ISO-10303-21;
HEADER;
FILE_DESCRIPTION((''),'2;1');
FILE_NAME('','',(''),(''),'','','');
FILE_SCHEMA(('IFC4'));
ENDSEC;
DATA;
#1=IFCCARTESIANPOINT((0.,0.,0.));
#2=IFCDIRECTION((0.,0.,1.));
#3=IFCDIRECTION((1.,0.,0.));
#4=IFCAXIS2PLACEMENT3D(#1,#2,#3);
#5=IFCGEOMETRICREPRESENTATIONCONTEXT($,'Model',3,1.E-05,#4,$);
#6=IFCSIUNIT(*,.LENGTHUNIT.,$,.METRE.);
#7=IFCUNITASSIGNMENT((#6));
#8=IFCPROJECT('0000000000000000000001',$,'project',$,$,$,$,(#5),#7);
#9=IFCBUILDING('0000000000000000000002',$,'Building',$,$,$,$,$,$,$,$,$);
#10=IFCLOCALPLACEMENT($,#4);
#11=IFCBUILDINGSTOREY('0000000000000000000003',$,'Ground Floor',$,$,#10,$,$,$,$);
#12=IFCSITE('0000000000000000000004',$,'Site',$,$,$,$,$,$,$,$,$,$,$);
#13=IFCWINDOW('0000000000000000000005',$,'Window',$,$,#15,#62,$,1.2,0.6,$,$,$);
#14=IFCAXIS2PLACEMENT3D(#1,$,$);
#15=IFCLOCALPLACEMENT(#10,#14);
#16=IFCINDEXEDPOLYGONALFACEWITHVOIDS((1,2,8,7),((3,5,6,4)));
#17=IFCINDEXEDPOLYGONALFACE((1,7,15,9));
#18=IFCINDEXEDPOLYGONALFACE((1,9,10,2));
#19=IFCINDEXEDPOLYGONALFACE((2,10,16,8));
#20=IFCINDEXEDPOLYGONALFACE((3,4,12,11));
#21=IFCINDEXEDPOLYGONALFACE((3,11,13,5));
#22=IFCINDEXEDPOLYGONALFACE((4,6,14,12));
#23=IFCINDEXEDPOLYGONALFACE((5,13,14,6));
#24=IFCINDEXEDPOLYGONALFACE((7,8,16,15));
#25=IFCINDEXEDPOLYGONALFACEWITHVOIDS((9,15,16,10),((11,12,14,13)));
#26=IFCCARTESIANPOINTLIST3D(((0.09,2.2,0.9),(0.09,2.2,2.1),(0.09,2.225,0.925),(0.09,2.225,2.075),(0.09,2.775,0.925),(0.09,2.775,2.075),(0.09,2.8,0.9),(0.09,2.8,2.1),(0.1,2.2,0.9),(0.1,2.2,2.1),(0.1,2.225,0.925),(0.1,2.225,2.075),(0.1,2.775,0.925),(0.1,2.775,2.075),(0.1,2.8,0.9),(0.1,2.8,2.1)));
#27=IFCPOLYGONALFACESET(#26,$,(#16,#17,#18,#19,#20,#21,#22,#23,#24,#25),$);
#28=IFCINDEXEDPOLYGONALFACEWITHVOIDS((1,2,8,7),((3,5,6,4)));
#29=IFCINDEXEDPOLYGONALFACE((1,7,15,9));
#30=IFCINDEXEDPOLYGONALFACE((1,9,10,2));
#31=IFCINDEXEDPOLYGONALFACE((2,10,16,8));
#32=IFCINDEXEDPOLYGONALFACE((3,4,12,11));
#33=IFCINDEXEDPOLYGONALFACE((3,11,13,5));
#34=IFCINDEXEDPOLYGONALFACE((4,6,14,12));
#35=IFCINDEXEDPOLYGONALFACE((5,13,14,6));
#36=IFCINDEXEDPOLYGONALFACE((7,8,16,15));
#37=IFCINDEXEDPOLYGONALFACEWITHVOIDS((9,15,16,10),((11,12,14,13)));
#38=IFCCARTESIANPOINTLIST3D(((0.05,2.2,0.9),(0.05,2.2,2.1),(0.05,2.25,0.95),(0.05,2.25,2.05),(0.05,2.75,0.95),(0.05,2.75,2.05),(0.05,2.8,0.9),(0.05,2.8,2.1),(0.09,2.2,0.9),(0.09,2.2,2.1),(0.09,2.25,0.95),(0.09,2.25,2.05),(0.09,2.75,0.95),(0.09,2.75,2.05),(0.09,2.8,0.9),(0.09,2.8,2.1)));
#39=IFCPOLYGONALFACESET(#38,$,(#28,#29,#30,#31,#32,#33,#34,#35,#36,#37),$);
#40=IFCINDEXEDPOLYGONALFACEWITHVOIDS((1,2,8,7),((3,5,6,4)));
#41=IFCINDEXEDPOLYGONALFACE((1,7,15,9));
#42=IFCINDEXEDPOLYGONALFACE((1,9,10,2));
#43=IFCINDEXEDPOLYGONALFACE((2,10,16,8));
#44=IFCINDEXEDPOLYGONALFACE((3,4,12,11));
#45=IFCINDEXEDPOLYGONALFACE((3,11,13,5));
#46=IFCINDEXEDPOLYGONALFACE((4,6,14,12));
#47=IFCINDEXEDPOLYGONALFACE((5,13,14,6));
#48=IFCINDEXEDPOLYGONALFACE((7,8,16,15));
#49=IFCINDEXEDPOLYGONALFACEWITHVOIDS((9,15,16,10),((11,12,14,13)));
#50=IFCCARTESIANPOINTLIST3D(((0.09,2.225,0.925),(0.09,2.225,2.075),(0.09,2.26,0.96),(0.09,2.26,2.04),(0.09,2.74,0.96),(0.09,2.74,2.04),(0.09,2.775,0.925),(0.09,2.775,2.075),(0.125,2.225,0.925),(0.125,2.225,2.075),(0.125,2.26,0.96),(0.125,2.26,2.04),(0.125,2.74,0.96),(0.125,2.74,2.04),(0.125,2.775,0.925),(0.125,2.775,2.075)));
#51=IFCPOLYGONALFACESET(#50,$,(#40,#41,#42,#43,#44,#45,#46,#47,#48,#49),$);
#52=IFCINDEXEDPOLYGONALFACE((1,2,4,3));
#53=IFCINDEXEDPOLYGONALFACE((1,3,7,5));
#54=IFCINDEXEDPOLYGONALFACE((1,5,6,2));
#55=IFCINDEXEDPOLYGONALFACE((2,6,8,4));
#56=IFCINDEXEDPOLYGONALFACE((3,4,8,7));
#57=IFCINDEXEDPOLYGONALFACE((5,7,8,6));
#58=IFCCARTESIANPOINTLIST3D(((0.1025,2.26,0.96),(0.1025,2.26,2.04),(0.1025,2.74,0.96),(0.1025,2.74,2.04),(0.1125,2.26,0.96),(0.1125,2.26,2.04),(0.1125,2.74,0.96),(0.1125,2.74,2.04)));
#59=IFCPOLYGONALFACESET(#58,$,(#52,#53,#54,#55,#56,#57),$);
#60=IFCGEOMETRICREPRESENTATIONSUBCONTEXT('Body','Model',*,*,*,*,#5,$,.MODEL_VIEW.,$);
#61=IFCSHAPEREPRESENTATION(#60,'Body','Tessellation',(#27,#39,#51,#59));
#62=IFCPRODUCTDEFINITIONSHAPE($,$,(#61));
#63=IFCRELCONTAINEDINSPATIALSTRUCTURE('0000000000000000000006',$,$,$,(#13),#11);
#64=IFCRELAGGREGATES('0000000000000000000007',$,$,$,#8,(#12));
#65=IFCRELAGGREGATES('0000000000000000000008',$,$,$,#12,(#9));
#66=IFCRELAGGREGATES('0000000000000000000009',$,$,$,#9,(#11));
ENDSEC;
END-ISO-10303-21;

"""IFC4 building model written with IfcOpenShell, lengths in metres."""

from ifc_helpers import new_model, si_unit, frame, origin_with_axes, place, context, subcontext, project, spatial, line, indexed_curve, outline, extrude, element, save


model = new_model("IFC4")

# Units and contexts
model_context = context("Model", 3, precision=1e-05, world=origin_with_axes())
body_context = subcontext(model_context, "Body", "Model", "MODEL_VIEW")
ifc_project = project(units=[si_unit("LENGTHUNIT", "METRE")], contexts=[model_context])

# Site, building, storey
site = spatial("IfcSite", under=ifc_project, Name="Site")
building = spatial("IfcBuilding", under=site, Name="Building")
storey_placement = place(None, origin_with_axes())
storey = spatial("IfcBuildingStorey", under=building, at=storey_placement, Name="Ground Floor")

# Window
window_1_placement = place(storey_placement, frame((0.0, 2.8, 0.9), z_axis=(0.0, 0.0, 1.0), x_axis=(0.0, -1.0, 0.0)))
element("IfcWindow", 1, at=window_1_placement, inside=storey, Name="Window", OverallHeight=1.2, OverallWidth=0.6, context=body_context, shape_type="SweptSolid", body=[
    extrude(outline(indexed_curve([(0.0, 0.0), (0.6, 0.0), (0.6, 1.2), (0.0, 1.2)], segments=[line(1, 2, 3, 4, 1)]), holes=[indexed_curve([(0.025, 0.025), (0.575, 0.025), (0.575, 1.175), (0.025, 1.175)], segments=[line(1, 2, 3, 4, 1)])]), frame((0.0, 0.09, 0.0), z_axis=(0.0, -1.0, 0.0), x_axis=(1.0, 0.0, 0.0)), (0.0, 0.0, -1.0), 0.01),
    extrude(outline(indexed_curve([(0.0, 0.0), (0.6, 0.0), (0.6, 1.2), (0.0, 1.2)], segments=[line(1, 2, 3, 4, 1)]), holes=[indexed_curve([(0.05, 0.05), (0.55, 0.05), (0.55, 1.15), (0.05, 1.15)], segments=[line(1, 2, 3, 4, 1)])]), frame((0.0, 0.05, 0.0), z_axis=(0.0, -1.0, 0.0), x_axis=(1.0, 0.0, 0.0)), (0.0, 0.0, -1.0), 0.04),
    extrude(outline(indexed_curve([(0.0, 0.0), (0.55, 0.0), (0.55, 1.15), (0.0, 1.15)], segments=[line(1, 2, 3, 4, 1)]), holes=[indexed_curve([(0.035, 0.035), (0.515, 0.035), (0.515, 1.115), (0.035, 1.115)], segments=[line(1, 2, 3, 4, 1)])]), frame((0.025, 0.09, 0.025), z_axis=(0.0, -1.0, 0.0), x_axis=(1.0, 0.0, 0.0)), (0.0, 0.0, -1.0), 0.035),
    extrude(outline(indexed_curve([(0.035, 0.035), (0.515, 0.035), (0.515, 1.115), (0.035, 1.115)], segments=[line(1, 2, 3, 4, 1)])), frame((0.025, 0.1025, 0.025), z_axis=(0.0, -1.0, 0.0), x_axis=(1.0, 0.0, 0.0)), (0.0, 0.0, -1.0), 0.01),
])

save(model, "model.ifc")
